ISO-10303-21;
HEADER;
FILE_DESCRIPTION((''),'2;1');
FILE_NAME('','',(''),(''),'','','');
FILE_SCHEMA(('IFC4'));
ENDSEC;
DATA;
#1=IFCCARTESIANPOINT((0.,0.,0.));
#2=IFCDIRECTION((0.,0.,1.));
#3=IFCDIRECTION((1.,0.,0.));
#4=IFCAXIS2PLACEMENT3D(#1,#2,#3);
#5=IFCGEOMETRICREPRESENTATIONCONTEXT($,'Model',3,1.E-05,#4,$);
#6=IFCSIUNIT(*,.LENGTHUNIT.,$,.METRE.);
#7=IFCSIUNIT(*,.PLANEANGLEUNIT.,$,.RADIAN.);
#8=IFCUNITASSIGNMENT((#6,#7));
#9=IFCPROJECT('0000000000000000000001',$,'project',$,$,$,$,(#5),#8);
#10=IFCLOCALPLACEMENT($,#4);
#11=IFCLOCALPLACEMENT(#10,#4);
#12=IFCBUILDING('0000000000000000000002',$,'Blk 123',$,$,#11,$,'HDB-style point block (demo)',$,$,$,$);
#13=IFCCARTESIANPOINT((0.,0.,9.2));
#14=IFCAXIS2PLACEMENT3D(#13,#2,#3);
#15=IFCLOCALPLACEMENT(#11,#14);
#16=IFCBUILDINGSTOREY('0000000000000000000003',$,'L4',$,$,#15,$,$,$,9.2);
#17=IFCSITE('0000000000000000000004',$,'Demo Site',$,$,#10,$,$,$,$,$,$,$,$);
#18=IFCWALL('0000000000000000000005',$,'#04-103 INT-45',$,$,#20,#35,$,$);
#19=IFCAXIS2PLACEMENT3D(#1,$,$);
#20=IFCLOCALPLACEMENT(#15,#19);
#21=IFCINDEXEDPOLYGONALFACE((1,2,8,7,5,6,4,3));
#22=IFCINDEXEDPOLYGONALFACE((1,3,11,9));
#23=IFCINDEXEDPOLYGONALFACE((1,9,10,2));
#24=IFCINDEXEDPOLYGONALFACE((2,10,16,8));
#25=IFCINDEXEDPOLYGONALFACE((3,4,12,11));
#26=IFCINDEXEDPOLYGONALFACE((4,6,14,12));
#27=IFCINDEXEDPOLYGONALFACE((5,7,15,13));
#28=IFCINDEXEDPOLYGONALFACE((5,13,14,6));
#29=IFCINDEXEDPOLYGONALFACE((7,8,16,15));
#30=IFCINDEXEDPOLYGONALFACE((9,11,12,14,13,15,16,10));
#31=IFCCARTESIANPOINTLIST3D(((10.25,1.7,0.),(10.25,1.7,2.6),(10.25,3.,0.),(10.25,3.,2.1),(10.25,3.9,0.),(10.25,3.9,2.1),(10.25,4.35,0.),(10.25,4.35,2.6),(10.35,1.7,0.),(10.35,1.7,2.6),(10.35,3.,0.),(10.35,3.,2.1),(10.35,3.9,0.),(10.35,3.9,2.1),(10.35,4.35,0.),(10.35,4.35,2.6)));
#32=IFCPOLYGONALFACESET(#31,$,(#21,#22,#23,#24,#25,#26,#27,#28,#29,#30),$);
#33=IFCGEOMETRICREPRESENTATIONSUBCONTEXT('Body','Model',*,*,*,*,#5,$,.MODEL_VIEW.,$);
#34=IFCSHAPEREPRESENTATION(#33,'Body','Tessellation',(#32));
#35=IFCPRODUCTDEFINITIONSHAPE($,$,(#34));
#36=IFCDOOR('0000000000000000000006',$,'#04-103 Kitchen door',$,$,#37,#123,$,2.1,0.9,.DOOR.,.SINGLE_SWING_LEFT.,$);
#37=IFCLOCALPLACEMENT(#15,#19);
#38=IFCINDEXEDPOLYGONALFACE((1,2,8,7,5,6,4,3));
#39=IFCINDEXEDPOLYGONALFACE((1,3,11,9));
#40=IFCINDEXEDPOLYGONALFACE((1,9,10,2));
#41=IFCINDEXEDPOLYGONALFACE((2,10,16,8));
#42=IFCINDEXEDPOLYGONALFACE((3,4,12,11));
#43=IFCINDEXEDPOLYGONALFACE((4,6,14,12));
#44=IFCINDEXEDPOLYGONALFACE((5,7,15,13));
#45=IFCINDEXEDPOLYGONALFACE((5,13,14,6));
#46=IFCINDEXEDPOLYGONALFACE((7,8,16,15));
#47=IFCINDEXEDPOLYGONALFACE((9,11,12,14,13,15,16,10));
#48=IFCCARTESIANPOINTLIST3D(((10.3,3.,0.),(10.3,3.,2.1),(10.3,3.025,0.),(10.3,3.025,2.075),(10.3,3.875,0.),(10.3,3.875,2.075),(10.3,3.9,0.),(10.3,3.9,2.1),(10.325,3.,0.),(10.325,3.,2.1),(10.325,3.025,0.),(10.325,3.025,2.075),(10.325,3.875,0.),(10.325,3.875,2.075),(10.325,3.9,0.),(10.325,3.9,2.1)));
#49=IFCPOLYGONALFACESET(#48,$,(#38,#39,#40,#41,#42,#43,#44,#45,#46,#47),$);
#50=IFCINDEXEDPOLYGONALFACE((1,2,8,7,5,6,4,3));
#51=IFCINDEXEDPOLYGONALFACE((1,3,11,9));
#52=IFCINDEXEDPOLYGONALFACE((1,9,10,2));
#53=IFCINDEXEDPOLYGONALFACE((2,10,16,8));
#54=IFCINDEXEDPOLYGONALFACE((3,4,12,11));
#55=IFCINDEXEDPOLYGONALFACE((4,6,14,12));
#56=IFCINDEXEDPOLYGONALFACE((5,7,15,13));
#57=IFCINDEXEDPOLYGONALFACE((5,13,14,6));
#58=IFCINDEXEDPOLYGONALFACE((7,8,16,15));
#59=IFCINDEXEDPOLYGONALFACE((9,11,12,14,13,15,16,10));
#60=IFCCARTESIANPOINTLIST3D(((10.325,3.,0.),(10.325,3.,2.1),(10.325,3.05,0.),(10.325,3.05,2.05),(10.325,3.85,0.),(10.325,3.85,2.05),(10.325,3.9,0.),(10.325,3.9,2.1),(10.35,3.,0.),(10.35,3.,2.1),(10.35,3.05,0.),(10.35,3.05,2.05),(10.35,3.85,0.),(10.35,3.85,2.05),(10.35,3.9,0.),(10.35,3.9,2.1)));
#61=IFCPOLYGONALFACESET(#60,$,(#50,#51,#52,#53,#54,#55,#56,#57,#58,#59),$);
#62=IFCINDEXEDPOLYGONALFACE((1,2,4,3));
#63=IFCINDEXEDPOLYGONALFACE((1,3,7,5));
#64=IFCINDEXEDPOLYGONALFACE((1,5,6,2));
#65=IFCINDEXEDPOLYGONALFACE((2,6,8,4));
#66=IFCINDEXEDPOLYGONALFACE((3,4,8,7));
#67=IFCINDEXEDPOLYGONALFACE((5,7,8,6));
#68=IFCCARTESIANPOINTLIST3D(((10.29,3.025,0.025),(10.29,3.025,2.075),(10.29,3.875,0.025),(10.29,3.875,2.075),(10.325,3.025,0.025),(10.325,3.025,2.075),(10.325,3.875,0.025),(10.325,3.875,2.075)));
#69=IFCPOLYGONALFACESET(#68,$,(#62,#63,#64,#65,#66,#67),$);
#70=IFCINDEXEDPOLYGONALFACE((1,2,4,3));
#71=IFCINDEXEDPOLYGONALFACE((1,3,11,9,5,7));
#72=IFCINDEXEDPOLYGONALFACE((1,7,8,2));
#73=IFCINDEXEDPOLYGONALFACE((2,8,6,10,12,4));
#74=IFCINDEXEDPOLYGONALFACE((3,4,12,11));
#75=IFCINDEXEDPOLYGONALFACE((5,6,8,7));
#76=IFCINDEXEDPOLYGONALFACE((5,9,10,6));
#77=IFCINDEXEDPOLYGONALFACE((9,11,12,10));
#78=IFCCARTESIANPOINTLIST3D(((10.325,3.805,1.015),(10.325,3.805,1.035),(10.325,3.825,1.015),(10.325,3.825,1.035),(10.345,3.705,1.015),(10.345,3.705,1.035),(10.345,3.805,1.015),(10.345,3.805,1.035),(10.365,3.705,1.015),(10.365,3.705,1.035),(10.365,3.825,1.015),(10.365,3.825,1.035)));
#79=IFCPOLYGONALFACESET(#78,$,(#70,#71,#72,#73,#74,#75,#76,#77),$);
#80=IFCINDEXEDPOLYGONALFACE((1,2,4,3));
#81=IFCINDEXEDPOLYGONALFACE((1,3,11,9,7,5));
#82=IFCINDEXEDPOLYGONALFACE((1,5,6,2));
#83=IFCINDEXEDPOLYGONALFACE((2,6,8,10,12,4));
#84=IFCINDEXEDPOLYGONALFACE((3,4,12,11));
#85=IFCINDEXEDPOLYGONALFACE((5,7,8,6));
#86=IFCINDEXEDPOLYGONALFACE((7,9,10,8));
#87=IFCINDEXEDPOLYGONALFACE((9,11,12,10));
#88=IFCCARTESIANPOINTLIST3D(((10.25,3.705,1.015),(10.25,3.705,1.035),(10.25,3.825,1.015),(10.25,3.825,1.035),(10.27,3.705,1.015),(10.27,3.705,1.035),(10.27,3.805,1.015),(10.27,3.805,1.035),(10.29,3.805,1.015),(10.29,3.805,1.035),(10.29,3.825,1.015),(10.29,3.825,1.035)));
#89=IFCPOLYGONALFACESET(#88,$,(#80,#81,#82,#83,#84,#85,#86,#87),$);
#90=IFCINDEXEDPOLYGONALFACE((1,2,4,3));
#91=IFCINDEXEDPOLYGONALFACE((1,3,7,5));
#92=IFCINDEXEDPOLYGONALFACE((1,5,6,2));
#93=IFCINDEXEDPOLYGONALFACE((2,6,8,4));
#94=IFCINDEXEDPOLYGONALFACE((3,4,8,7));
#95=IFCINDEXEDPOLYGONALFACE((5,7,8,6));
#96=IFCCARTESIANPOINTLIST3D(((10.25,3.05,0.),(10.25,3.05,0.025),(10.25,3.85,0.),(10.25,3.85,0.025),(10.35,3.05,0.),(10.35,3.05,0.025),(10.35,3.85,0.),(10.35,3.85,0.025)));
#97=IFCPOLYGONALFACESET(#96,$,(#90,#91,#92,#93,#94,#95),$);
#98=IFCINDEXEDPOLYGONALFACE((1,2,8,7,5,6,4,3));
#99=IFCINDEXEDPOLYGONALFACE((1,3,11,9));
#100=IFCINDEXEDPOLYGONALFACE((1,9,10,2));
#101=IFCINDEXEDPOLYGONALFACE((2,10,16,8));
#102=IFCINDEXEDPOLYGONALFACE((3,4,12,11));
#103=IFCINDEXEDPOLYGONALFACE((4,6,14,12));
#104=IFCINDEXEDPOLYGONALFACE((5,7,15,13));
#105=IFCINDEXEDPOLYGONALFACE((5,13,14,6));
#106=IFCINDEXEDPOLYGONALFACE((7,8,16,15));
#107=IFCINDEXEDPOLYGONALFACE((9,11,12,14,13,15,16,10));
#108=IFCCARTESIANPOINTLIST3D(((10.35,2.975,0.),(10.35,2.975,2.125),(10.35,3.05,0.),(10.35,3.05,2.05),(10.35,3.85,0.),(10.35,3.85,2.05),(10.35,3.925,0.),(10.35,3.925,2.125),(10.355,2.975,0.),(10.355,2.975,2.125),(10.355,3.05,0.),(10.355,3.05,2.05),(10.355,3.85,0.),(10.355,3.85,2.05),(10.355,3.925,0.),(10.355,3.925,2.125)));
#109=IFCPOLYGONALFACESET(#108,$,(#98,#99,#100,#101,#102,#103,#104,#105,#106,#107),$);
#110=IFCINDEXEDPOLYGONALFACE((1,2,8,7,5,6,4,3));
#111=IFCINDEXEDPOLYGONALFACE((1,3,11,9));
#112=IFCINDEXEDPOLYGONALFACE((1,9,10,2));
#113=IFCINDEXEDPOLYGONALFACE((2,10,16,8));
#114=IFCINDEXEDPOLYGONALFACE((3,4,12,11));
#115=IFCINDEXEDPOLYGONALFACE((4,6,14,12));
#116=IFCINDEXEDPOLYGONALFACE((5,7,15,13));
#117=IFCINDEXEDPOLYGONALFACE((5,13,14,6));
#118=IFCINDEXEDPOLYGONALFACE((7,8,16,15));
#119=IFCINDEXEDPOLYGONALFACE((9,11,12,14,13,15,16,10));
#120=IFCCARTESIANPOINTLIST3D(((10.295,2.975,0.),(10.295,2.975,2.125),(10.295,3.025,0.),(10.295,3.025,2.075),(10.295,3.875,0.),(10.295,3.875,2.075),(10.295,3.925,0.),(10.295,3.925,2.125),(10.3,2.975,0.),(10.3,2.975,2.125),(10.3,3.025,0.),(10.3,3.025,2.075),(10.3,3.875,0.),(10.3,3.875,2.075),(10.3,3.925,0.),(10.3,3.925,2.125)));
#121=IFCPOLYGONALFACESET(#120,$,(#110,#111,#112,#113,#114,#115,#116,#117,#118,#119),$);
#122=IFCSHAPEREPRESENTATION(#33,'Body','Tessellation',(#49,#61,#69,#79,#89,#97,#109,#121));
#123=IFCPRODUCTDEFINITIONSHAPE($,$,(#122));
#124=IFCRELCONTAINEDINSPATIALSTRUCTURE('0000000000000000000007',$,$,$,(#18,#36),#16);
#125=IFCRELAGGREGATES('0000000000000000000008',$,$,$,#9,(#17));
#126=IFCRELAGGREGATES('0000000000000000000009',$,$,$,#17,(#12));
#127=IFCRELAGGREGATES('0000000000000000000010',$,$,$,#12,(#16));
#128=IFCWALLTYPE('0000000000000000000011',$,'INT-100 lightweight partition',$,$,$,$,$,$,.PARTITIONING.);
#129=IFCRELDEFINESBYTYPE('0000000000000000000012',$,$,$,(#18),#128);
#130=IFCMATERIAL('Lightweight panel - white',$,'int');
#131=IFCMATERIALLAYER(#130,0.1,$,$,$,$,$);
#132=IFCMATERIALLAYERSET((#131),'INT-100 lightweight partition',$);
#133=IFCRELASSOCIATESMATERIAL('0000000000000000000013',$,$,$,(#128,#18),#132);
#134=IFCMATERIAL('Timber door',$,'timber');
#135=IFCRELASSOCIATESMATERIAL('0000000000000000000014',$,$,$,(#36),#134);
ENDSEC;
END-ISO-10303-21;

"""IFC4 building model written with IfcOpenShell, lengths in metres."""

from ifc_helpers import new_model, si_unit, frame, origin_with_axes, place, context, subcontext, project, spatial, line, indexed_curve, outline, extrude, material, layer, layer_set, layer_usage, type_object, element, fill, save


model = new_model("IFC4")

# Units and contexts
model_context = context("Model", 3, precision=1e-05, world=origin_with_axes())
body_context = subcontext(model_context, "Body", "Model", "MODEL_VIEW")
ifc_project = project(units=[si_unit("LENGTHUNIT", "METRE"), si_unit("PLANEANGLEUNIT", "RADIAN")], contexts=[model_context])

# Site, building, storey
site_placement = place(None, origin_with_axes())
site = spatial("IfcSite", under=ifc_project, at=site_placement, Name="Demo Site")
building_placement = place(site_placement, origin_with_axes())
building = spatial("IfcBuilding", under=site, at=building_placement, Name="Blk 123", LongName="HDB-style point block (demo)")
storey_placement = place(building_placement, frame((0.0, 0.0, 9.2), z_axis=(0.0, 0.0, 1.0), x_axis=(1.0, 0.0, 0.0)))
storey = spatial("IfcBuildingStorey", under=building, at=storey_placement, Name="L4", Elevation=9.2)

# Shared definitions
ifc_material_1 = material(Name="Timber door", Category="timber")

# Wall, opening, door
ifc_material_2 = material(Name="Lightweight panel - white", Category="int")
ifc_layer_1 = layer(ifc_material_2, 0.1)
ifc_layer_set_1 = layer_set([ifc_layer_1], Name="INT-100 lightweight partition")
ifc_layer_usage_1 = layer_usage(ifc_layer_set_1, "AXIS2", "POSITIVE", -0.05)
wall_type_1 = type_object("IfcWallType", Name="INT-100 lightweight partition", PredefinedType="PARTITIONING", material=ifc_layer_set_1)
wall_1_placement = place(storey_placement, frame((10.3, 1.7, 0.0), z_axis=(0.0, 0.0, 1.0), x_axis=(0.0, 1.0, 0.0)))
wall_1 = element("IfcWall", 1, at=wall_1_placement, inside=storey, type_object=wall_type_1, material=ifc_layer_usage_1, Name="#04-103 INT-45", context=body_context, shape_type="SweptSolid", body=[
    extrude(outline(indexed_curve([(0.0, 0.0), (0.0, 0.1), (2.65, 0.1), (2.65, 0.0), (0.0, 0.0)], self_intersect=False)), frame((0.0, -0.05, 0.0), z_axis=(0.0, 0.0, 1.0), x_axis=(1.0, 0.0, 0.0)), (0.0, 0.0, 1.0), 2.6),
])
opening_1_placement = place(wall_1_placement, frame((1.3, -0.15, 0.0), z_axis=(0.0, 0.0, 1.0), x_axis=(1.0, 0.0, 0.0)))
opening_1 = element("IfcOpeningElement", 2, at=opening_1_placement, cuts=wall_1, context=body_context, shape_type="SweptSolid", body=[
    extrude(outline(indexed_curve([(0.0, 0.0), (0.0, 0.3), (0.9, 0.3), (0.9, 0.0), (0.0, 0.0)], self_intersect=False)), origin_with_axes(), (0.0, 0.0, 1.0), 2.1),
])
door_1_placement = place(opening_1_placement, frame((0.0, 0.1, 0.0), z_axis=(0.0, 0.0, 1.0), x_axis=(1.0, 0.0, 0.0)))
door_1 = element("IfcDoor", 3, at=door_1_placement, inside=storey, material=ifc_material_1, Name="#04-103 Kitchen door", OperationType="SINGLE_SWING_LEFT", OverallHeight=2.1, OverallWidth=0.9, PredefinedType="DOOR", context=body_context, shape_type="SweptSolid", body=[
    extrude(outline(indexed_curve([(0.0, 0.0), (0.0, 2.1), (0.9, 2.1), (0.9, 0.0), (0.875, 0.0), (0.875, 2.075), (0.025, 2.075), (0.025, 0.0)], segments=[line(1, 2, 3, 4, 5, 6, 7, 8, 1)])), frame((0.0, 0.025, 0.0), z_axis=(0.0, -1.0, 0.0), x_axis=(1.0, 0.0, 0.0)), (0.0, 0.0, -1.0), 0.025),
    extrude(outline(indexed_curve([(0.0, 0.0), (0.0, 2.1), (0.9, 2.1), (0.9, 0.0), (0.85, 0.0), (0.85, 2.05), (0.05, 2.05), (0.05, 0.0)], segments=[line(1, 2, 3, 4, 5, 6, 7, 8, 1)])), frame((0.0, 0.0, 0.0), z_axis=(0.0, -1.0, 0.0), x_axis=(1.0, 0.0, 0.0)), (0.0, 0.0, -1.0), 0.025),
    extrude(outline(indexed_curve([(0.0, 0.0), (0.85, 0.0), (0.85, 0.035), (0.0, 0.035)], segments=[line(1, 2, 3, 4, 1)])), frame((0.025, 0.025, 0.025), z_axis=(0.0, 0.0, 1.0), x_axis=(1.0, 0.0, 0.0)), (0.0, 0.0, 1.0), 2.05),
    extrude(outline(indexed_curve([(0.0, 0.0), (0.0, -0.04), (-0.12, -0.04), (-0.12, -0.02), (-0.02, -0.02), (-0.02, 0.0)], segments=[line(1, 2, 3, 4, 5, 6, 1)])), frame((0.825, 0.025, 1.015), z_axis=(0.0, 0.0, 1.0), x_axis=(1.0, 0.0, 0.0)), (0.0, 0.0, 1.0), 0.02),
    extrude(outline(indexed_curve([(0.0, 0.0), (0.0, 0.04), (-0.12, 0.04), (-0.12, 0.02), (-0.02, 0.02), (-0.02, 0.0)], segments=[line(1, 2, 3, 4, 5, 6, 1)])), frame((0.825, 0.06, 1.015), z_axis=(0.0, 0.0, 1.0), x_axis=(1.0, 0.0, 0.0)), (0.0, 0.0, 1.0), 0.02),
    extrude(outline(indexed_curve([(0.0, 0.0), (0.8, 0.0), (0.8, 0.1), (0.0, 0.1)], segments=[line(1, 2, 3, 4, 1)])), frame((0.05, 0.0, 0.0), z_axis=(0.0, 0.0, 1.0), x_axis=(1.0, 0.0, 0.0)), (0.0, 0.0, 1.0), 0.025),
    extrude(outline(indexed_curve([(0.0, 0.0), (0.0, 2.125), (0.95, 2.125), (0.95, 0.0), (0.875, 0.0), (0.875, 2.05), (0.075, 2.05), (0.075, 0.0)], segments=[line(1, 2, 3, 4, 5, 6, 7, 8, 1)])), frame((-0.025, -0.005, 0.0), z_axis=(0.0, -1.0, 0.0), x_axis=(1.0, 0.0, 0.0)), (0.0, 0.0, -1.0), 0.005),
    extrude(outline(indexed_curve([(0.0, 0.0), (0.0, 2.125), (0.95, 2.125), (0.95, 0.0), (0.9, 0.0), (0.9, 2.075), (0.05, 2.075), (0.05, 0.0)], segments=[line(1, 2, 3, 4, 5, 6, 7, 8, 1)])), frame((-0.025, 0.05, 0.0), z_axis=(0.0, -1.0, 0.0), x_axis=(1.0, 0.0, 0.0)), (0.0, 0.0, -1.0), 0.005),
])
fill(opening_1, door_1)

save(model, "model.ifc")
